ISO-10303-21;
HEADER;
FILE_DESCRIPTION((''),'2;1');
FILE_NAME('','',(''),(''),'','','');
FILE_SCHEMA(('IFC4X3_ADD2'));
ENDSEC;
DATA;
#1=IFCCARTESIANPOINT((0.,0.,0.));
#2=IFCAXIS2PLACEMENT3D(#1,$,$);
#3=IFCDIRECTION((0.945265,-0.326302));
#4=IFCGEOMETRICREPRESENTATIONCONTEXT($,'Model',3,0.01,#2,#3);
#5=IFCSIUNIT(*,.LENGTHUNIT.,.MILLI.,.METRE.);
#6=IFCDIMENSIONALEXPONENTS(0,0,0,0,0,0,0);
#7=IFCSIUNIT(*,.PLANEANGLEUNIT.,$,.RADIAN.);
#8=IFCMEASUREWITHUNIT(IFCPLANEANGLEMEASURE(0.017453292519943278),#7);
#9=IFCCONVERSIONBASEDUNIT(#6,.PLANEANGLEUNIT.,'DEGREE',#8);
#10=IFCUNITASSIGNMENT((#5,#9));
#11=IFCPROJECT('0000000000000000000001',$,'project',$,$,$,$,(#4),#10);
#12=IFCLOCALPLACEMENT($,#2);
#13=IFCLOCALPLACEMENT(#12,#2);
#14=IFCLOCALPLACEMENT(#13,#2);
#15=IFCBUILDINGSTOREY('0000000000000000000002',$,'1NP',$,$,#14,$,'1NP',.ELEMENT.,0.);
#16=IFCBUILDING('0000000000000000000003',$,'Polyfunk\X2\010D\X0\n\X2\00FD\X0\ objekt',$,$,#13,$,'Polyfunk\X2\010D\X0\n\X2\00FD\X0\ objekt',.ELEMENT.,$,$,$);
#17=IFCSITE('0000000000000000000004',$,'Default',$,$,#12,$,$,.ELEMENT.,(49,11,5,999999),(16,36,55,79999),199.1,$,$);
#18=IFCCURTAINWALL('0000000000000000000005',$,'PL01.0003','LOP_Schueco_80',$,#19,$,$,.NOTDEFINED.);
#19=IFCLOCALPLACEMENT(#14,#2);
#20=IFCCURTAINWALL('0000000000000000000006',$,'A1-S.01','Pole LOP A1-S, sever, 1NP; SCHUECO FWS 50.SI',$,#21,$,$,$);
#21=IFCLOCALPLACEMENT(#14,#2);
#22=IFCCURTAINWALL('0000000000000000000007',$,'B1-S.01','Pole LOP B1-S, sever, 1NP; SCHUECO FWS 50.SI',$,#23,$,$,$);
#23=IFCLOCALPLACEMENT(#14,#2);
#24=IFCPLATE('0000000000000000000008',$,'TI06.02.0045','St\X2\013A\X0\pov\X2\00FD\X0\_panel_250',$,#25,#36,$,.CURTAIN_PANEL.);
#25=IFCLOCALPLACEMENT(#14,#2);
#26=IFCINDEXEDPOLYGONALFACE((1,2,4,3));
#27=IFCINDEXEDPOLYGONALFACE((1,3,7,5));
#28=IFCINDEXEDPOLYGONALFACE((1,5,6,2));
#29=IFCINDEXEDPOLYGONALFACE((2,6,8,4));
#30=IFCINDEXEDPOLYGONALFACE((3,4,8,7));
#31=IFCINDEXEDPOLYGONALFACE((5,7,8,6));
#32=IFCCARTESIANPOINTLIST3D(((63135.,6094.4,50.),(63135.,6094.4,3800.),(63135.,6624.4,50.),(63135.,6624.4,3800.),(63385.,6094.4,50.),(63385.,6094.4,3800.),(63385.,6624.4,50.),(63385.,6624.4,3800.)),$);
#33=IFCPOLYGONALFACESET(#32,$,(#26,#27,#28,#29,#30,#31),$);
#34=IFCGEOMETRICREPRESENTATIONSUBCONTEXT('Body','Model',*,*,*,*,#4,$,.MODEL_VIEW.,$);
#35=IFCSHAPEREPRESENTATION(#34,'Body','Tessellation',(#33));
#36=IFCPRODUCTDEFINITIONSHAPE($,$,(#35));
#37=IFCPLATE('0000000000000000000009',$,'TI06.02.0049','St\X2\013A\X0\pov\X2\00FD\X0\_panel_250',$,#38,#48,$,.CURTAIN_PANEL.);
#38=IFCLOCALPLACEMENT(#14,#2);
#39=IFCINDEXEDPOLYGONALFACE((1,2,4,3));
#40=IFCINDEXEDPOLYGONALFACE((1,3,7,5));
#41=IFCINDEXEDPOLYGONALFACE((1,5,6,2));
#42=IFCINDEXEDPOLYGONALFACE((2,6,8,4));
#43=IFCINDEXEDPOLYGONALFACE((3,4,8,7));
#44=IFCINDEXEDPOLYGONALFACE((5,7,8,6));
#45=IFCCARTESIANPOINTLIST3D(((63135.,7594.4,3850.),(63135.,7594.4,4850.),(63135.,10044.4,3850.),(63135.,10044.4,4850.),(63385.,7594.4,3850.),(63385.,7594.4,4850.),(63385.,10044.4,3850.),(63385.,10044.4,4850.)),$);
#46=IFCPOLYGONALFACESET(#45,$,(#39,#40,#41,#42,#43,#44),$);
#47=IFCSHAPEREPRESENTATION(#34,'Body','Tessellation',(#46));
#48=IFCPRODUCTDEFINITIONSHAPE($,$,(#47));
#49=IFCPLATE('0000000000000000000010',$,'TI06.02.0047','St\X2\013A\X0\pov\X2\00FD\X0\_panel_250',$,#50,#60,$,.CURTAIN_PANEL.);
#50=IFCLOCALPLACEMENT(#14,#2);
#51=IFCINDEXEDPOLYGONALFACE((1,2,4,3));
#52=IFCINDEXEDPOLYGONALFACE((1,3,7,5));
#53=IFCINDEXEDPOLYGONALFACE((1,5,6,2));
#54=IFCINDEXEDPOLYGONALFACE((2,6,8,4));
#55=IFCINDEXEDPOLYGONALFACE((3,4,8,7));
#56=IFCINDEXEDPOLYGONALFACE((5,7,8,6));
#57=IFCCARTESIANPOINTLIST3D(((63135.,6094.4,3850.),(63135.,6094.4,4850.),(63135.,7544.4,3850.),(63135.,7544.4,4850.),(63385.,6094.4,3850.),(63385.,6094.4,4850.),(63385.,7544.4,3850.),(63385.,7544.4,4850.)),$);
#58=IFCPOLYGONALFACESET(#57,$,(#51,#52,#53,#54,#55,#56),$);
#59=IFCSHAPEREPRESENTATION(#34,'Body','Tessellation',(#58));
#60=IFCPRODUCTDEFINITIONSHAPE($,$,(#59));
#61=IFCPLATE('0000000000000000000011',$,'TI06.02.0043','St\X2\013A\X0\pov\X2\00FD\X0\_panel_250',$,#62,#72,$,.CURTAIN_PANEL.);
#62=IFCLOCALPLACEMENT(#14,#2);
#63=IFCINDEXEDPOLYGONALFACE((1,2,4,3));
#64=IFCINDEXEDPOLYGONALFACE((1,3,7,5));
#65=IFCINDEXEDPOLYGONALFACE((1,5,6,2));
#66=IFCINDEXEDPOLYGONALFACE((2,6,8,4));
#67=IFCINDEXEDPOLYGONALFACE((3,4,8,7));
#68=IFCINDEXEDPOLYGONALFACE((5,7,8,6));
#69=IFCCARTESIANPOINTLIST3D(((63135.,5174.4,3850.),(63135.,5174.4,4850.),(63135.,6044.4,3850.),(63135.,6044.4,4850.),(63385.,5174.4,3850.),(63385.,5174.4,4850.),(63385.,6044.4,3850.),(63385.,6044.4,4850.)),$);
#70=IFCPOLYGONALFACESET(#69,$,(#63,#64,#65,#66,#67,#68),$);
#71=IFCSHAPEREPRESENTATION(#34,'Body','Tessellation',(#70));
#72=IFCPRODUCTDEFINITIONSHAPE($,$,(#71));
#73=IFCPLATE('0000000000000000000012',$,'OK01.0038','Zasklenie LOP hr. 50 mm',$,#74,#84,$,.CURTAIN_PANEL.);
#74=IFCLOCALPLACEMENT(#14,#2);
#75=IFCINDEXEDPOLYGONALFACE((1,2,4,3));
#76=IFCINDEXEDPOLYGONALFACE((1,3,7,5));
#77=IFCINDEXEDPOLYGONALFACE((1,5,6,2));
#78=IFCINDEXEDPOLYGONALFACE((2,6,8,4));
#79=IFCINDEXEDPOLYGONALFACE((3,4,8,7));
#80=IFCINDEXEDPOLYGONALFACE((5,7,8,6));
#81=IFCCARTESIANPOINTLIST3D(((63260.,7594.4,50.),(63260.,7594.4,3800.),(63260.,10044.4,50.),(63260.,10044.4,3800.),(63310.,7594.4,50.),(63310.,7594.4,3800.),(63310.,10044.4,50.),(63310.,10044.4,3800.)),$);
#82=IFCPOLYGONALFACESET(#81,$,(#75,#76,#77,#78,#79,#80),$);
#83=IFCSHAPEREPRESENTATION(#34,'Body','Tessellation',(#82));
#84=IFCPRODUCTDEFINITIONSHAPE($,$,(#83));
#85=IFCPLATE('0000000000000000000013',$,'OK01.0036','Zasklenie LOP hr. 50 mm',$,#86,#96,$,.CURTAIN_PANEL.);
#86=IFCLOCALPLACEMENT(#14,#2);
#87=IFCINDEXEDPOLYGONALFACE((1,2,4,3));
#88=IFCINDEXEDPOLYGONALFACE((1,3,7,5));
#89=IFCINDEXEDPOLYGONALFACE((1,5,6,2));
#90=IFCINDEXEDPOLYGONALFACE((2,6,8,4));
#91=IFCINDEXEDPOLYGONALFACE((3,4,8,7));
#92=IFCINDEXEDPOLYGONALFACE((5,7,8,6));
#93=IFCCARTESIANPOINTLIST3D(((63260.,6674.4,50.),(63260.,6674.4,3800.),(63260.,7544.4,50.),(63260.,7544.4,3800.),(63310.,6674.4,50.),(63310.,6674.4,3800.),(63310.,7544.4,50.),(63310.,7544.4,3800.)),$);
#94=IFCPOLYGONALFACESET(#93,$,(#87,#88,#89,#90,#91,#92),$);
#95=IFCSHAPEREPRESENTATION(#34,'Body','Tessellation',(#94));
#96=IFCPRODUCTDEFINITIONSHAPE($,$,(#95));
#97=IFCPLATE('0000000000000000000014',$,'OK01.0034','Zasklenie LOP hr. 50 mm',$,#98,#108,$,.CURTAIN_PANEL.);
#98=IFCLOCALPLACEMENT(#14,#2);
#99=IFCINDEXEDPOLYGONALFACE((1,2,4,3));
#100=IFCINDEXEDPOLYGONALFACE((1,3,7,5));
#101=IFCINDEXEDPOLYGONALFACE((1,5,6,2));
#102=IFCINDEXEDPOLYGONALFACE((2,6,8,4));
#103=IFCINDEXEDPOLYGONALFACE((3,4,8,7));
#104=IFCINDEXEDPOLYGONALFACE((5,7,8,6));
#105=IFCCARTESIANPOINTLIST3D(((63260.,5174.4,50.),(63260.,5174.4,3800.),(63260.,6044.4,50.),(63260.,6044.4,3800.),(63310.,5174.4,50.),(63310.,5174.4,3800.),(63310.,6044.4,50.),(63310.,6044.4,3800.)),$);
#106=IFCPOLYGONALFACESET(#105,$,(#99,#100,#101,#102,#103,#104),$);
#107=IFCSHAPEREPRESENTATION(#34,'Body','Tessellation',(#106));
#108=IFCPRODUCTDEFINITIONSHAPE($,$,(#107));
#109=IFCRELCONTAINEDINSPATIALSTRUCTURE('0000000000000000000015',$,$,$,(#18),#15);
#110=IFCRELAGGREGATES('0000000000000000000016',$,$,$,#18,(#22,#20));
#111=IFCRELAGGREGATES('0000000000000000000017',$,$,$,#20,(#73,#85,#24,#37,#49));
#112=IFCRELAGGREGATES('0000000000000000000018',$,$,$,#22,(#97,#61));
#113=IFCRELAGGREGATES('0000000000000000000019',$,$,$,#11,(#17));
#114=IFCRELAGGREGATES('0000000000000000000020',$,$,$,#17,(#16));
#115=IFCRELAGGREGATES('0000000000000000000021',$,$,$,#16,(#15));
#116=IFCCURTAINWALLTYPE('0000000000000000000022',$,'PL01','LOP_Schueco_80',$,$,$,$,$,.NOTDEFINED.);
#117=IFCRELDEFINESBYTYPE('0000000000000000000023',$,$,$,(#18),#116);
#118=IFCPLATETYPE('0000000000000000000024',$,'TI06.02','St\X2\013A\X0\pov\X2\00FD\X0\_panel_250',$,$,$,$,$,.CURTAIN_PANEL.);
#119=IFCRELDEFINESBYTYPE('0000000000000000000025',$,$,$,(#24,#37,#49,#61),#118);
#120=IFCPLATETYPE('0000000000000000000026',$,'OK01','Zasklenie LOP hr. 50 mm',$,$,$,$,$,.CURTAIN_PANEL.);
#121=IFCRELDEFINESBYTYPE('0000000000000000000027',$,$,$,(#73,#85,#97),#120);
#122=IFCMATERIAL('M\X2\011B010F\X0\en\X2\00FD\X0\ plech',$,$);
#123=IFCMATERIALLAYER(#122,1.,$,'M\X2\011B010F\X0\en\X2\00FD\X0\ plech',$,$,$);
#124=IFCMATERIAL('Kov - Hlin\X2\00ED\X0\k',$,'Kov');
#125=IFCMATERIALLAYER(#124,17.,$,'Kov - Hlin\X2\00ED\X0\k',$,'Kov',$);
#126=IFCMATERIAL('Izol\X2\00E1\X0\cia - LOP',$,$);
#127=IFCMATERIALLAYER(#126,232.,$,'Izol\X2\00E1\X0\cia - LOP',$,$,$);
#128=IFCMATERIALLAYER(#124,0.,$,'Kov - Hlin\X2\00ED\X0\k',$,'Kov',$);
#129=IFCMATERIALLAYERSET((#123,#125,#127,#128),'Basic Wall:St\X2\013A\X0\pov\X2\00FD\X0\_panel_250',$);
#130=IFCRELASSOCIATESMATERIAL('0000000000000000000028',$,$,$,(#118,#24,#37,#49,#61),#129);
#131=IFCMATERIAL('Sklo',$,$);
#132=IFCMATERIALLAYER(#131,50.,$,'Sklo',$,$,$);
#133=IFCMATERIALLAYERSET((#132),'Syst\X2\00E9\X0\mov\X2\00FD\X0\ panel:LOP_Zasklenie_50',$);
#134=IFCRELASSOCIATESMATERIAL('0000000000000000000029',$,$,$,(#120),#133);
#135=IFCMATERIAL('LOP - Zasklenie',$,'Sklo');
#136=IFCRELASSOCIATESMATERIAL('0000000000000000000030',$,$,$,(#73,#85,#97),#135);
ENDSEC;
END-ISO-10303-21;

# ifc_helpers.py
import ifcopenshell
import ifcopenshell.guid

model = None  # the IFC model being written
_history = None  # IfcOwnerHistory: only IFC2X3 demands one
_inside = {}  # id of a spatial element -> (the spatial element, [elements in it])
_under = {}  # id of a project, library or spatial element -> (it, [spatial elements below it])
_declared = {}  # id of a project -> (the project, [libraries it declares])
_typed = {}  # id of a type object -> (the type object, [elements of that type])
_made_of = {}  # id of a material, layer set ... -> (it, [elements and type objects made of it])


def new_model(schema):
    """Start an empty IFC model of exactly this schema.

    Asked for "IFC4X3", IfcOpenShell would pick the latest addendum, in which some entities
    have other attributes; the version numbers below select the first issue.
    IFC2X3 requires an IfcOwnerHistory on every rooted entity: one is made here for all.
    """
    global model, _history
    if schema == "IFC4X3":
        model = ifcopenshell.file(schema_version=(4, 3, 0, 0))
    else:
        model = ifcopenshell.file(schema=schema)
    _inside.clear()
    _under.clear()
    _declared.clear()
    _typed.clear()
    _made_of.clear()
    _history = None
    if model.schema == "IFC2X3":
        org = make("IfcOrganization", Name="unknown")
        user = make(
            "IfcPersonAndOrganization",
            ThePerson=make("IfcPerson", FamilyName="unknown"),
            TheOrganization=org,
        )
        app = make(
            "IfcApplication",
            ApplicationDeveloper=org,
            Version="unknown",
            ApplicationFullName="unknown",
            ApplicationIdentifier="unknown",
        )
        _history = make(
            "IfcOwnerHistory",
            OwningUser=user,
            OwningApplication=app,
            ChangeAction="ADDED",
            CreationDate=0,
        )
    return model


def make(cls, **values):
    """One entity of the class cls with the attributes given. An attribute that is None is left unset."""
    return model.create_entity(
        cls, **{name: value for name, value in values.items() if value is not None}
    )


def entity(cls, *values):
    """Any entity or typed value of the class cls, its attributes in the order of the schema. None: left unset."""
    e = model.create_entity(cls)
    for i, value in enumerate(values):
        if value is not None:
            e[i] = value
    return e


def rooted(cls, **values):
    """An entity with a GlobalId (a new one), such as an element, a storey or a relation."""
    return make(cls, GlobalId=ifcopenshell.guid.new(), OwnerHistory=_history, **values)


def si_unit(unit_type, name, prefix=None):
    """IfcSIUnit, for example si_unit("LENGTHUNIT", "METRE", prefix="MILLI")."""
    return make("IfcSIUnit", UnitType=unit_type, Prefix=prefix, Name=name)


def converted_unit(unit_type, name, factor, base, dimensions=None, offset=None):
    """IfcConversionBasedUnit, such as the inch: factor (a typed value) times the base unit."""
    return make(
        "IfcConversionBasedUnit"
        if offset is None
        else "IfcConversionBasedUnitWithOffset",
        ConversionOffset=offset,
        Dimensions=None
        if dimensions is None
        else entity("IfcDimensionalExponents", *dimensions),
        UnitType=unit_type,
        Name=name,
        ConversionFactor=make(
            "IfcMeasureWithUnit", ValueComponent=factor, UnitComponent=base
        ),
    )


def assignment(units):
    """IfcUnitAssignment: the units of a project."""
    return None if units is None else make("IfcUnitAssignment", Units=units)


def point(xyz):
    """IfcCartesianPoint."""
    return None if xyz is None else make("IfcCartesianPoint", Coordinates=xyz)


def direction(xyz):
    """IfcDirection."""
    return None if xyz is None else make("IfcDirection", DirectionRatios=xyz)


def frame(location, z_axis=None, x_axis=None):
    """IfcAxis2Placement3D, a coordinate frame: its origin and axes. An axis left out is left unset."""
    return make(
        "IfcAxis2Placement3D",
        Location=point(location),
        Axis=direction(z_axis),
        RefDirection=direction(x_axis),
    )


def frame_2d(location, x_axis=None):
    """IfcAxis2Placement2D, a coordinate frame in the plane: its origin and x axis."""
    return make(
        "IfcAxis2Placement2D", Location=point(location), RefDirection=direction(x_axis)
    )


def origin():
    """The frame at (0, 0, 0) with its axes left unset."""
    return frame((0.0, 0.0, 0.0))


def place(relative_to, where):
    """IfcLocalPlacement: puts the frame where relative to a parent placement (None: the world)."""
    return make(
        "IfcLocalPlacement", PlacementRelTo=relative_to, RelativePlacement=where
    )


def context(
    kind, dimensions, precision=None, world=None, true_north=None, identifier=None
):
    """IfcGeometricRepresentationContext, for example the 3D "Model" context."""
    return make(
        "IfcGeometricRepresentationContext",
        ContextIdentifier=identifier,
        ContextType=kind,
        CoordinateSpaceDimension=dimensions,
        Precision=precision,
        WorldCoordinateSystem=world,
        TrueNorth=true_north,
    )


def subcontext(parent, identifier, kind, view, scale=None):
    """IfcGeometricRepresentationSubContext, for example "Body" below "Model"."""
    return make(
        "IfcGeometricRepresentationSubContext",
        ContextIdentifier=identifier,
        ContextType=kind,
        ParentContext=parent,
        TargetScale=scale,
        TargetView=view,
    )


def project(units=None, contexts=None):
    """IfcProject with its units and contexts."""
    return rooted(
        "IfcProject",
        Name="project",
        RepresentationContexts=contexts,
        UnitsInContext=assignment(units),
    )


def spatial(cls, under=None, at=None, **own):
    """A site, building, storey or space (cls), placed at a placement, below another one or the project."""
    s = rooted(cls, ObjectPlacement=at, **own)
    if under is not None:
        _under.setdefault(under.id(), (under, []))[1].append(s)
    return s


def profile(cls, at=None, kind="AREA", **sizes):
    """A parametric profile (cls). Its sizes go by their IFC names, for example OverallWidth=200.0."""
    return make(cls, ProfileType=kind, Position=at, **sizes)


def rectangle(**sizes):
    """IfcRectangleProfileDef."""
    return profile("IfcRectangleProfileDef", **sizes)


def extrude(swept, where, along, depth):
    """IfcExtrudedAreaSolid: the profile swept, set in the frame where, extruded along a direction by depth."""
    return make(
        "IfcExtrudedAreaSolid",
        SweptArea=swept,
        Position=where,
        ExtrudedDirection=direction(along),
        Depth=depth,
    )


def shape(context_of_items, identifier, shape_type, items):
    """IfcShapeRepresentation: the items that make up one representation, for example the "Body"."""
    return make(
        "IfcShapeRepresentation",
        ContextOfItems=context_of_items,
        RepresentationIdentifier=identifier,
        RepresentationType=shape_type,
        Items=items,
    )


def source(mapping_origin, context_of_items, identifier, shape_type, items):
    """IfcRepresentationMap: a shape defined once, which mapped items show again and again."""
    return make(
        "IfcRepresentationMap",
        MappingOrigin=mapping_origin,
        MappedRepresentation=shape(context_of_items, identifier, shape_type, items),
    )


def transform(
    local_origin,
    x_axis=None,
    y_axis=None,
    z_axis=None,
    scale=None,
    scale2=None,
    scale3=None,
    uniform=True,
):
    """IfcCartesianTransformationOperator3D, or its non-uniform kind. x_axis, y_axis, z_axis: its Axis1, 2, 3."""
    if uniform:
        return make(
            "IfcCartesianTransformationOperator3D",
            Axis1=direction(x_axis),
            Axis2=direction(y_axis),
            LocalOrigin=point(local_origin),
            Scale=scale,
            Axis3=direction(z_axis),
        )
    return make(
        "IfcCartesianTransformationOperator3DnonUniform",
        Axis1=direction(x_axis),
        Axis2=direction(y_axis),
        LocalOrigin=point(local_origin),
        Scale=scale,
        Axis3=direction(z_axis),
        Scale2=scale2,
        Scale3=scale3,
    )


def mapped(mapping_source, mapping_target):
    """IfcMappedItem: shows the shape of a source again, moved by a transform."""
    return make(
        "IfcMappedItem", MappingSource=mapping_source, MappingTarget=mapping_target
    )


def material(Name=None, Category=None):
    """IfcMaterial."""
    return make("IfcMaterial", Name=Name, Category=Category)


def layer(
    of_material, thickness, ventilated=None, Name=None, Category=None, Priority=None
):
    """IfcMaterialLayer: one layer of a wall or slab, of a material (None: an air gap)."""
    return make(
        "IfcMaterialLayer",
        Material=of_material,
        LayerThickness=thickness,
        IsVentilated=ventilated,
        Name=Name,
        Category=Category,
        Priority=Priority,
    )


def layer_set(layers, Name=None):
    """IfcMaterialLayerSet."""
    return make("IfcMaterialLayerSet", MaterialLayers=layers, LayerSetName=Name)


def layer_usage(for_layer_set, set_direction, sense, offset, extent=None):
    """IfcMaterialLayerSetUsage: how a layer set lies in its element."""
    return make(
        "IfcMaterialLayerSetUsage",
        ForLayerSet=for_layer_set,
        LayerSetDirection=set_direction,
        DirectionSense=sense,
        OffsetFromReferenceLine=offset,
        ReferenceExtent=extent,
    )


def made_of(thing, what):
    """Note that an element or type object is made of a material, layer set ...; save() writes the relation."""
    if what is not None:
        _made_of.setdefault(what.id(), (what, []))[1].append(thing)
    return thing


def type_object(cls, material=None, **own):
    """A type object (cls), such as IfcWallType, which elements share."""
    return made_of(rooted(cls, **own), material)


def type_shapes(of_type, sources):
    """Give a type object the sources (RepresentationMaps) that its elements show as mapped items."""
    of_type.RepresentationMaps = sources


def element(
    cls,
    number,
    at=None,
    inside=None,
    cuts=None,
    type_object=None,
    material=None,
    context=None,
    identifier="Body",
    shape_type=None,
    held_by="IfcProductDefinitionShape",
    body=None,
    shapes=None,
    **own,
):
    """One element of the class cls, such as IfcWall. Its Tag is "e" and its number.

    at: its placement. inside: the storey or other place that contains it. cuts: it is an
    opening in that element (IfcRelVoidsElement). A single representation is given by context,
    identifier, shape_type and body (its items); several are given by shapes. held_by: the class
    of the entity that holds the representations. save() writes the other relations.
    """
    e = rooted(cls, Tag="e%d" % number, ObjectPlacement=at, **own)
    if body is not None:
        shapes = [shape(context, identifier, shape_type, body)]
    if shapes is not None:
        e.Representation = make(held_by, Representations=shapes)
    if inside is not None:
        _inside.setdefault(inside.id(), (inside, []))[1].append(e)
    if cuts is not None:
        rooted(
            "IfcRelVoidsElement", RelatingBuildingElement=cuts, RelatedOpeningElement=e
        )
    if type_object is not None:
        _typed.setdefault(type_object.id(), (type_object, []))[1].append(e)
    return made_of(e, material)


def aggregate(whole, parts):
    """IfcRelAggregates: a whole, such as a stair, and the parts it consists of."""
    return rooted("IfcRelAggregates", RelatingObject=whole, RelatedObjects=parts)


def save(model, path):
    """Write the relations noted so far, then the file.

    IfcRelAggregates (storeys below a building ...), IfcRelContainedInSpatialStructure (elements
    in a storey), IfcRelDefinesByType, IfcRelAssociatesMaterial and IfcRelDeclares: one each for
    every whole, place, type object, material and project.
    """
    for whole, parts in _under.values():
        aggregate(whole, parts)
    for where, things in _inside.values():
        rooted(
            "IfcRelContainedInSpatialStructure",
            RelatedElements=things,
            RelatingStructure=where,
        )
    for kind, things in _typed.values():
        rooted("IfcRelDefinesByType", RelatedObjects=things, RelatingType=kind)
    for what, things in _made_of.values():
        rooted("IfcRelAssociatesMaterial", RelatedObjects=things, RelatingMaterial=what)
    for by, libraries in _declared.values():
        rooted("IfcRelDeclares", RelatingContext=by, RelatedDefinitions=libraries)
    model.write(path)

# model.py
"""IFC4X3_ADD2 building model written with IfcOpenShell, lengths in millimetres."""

from ifc_helpers import new_model, entity, si_unit, converted_unit, direction, frame, frame_2d, origin, place, context, subcontext, project, spatial, rectangle, extrude, source, transform, mapped, material, layer, layer_set, layer_usage, type_object, type_shapes, element, aggregate, save


model = new_model("IFC4X3_ADD2")

# Units and contexts
model_context = context("Model", 3, precision=0.01, world=origin(), true_north=direction((0.945265, -0.326302)))
body_context = subcontext(model_context, "Body", "Model", "MODEL_VIEW")
ifc_project = project(units=[si_unit("LENGTHUNIT", "METRE", prefix="MILLI"), converted_unit("PLANEANGLEUNIT", "DEGREE", entity("IfcPlaneAngleMeasure", 0.017453292519943278), si_unit("PLANEANGLEUNIT", "RADIAN"), dimensions=[0, 0, 0, 0, 0, 0, 0])], contexts=[model_context])

# Site, building, storey
site_placement = place(None, origin())
site = spatial("IfcSite", under=ifc_project, at=site_placement, Name="Default", CompositionType="ELEMENT", RefLatitude=(49, 11, 5, 999999), RefLongitude=(16, 36, 55, 79999), RefElevation=199.1)
building_placement = place(site_placement, origin())
building = spatial("IfcBuilding", under=site, at=building_placement, Name="Polyfunkčný objekt", LongName="Polyfunkčný objekt", CompositionType="ELEMENT")
storey_placement = place(building_placement, origin())
storey = spatial("IfcBuildingStorey", under=building, at=storey_placement, Name="1NP", LongName="1NP", CompositionType="ELEMENT", Elevation=0.0)

# Curtain walls, plates
curtain_wall_type = type_object("IfcCurtainWallType", Name="PL01", Description="LOP_Schueco_80", PredefinedType="NOTDEFINED")
curtain_wall_1_placement = place(storey_placement, origin())
curtain_wall_1 = element("IfcCurtainWall", 1, at=curtain_wall_1_placement, inside=storey, type_object=curtain_wall_type, Name="PL01.0003", Description="LOP_Schueco_80", PredefinedType="NOTDEFINED")
curtain_wall_2 = element("IfcCurtainWall", 2, Name="A1-S.01", Description="Pole LOP A1-S, sever, 1NP; SCHUECO FWS 50.SI")
curtain_wall_3 = element("IfcCurtainWall", 3, Name="B1-S.01", Description="Pole LOP B1-S, sever, 1NP; SCHUECO FWS 50.SI")
aggregate(curtain_wall_1, [curtain_wall_3, curtain_wall_2])
ifc_material_1 = material(Name="Měďený plech")
ifc_layer_1 = layer(ifc_material_1, 1.0, Name="Měďený plech")
ifc_material_2 = material(Name="Kov - Hliník", Category="Kov")
ifc_layer_2 = layer(ifc_material_2, 17.0, Name="Kov - Hliník", Category="Kov")
ifc_material_3 = material(Name="Izolácia - LOP")
ifc_layer_3 = layer(ifc_material_3, 232.0, Name="Izolácia - LOP")
ifc_layer_4 = layer(ifc_material_2, 0.0, Name="Kov - Hliník", Category="Kov")
ifc_layer_set_1 = layer_set([ifc_layer_1, ifc_layer_2, ifc_layer_3, ifc_layer_4], Name="Basic Wall:Stĺpový_panel_250")
ifc_layer_usage_1 = layer_usage(ifc_layer_set_1, "AXIS2", "NEGATIVE", 125.0)
plate_type_1 = type_object("IfcPlateType", Name="TI06.02", Description="Stĺpový_panel_250", PredefinedType="CURTAIN_PANEL", material=ifc_layer_set_1)
plate_1_placement = place(storey_placement, frame((63260.0, 6624.4, 50.0), z_axis=(0.0, 0.0, 1.0), x_axis=(0.0, -1.0, 0.0)))
plate_1 = element("IfcPlate", 4, at=plate_1_placement, type_object=plate_type_1, material=ifc_layer_usage_1, Name="TI06.02.0045", Description="Stĺpový_panel_250", PredefinedType="CURTAIN_PANEL", context=body_context, shape_type="SweptSolid", body=[
    extrude(rectangle(XDim=250.0, YDim=530.0, at=frame_2d((0.0, 0.0), x_axis=(1.0, 0.0))), frame((265.0, 0.0, 0.0), z_axis=(0.0, 0.0, 1.0), x_axis=(0.0, 1.0, 0.0)), (0.0, 0.0, 1.0), 3750.0),
])
ifc_layer_usage_2 = layer_usage(ifc_layer_set_1, "AXIS2", "NEGATIVE", 125.0)
plate_2_placement = place(storey_placement, frame((63260.0, 10044.4, 3850.0), z_axis=(0.0, 0.0, 1.0), x_axis=(0.0, -1.0, 0.0)))
plate_2 = element("IfcPlate", 5, at=plate_2_placement, type_object=plate_type_1, material=ifc_layer_usage_2, Name="TI06.02.0049", Description="Stĺpový_panel_250", PredefinedType="CURTAIN_PANEL", context=body_context, shape_type="SweptSolid", body=[
    extrude(rectangle(XDim=250.0, YDim=2450.0, at=frame_2d((0.0, 0.0), x_axis=(1.0, 0.0))), frame((1225.0, 0.0, 0.0), z_axis=(0.0, 0.0, 1.0), x_axis=(0.0, 1.0, 0.0)), (0.0, 0.0, 1.0), 1000.0),
])
ifc_layer_usage_3 = layer_usage(ifc_layer_set_1, "AXIS2", "NEGATIVE", 125.0)
plate_3_placement = place(storey_placement, frame((63260.0, 7544.4, 3850.0), z_axis=(0.0, 0.0, 1.0), x_axis=(0.0, -1.0, 0.0)))
plate_3 = element("IfcPlate", 6, at=plate_3_placement, type_object=plate_type_1, material=ifc_layer_usage_3, Name="TI06.02.0047", Description="Stĺpový_panel_250", PredefinedType="CURTAIN_PANEL", context=body_context, shape_type="SweptSolid", body=[
    extrude(rectangle(XDim=250.0, YDim=1450.0, at=frame_2d((0.0, 0.0), x_axis=(1.0, 0.0))), frame((725.0, 0.0, 0.0), z_axis=(0.0, 0.0, 1.0), x_axis=(0.0, 1.0, 0.0)), (0.0, 0.0, 1.0), 1000.0),
])
ifc_layer_usage_4 = layer_usage(ifc_layer_set_1, "AXIS2", "NEGATIVE", 125.0)
plate_4_placement = place(storey_placement, frame((63260.0, 6044.4, 3850.0), z_axis=(0.0, 0.0, 1.0), x_axis=(0.0, -1.0, 0.0)))
plate_4 = element("IfcPlate", 7, at=plate_4_placement, type_object=plate_type_1, material=ifc_layer_usage_4, Name="TI06.02.0043", Description="Stĺpový_panel_250", PredefinedType="CURTAIN_PANEL", context=body_context, shape_type="SweptSolid", body=[
    extrude(rectangle(XDim=250.0, YDim=870.0, at=frame_2d((0.0, 0.0), x_axis=(1.0, 0.0))), frame((435.0, 0.0, 0.0), z_axis=(0.0, 0.0, 1.0), x_axis=(0.0, 1.0, 0.0)), (0.0, 0.0, 1.0), 1000.0),
])
ifc_material_4 = material(Name="LOP - Zasklenie", Category="Sklo")
ifc_material_5 = material(Name="Sklo")
ifc_layer_5 = layer(ifc_material_5, 50.0, Name="Sklo")
ifc_layer_set_2 = layer_set([ifc_layer_5], Name="Systémový panel:LOP_Zasklenie_50")
plate_type_2 = type_object("IfcPlateType", Name="OK01", Description="Zasklenie LOP hr. 50 mm", PredefinedType="CURTAIN_PANEL", material=ifc_layer_set_2)
shared_shape_1 = source(origin(), body_context, "Body", "SweptSolid", [
    extrude(rectangle(XDim=3750.0, YDim=2450.0, at=frame_2d((-141.7, 0.0), x_axis=(1.0, 0.0))), frame((0.0, 0.0, 2016.7), z_axis=(0.0, 1.0, 0.0), x_axis=(0.0, 0.0, 1.0)), (0.0, 0.0, 1.0), 50.0),
])
plate_5_placement = place(curtain_wall_1_placement, frame((63260.0, 8819.4, 50.0), z_axis=(0.0, 0.0, 1.0), x_axis=(0.0, -1.0, 0.0)))
plate_5 = element("IfcPlate", 8, at=plate_5_placement, type_object=plate_type_2, material=ifc_material_4, Name="OK01.0038", Description="Zasklenie LOP hr. 50 mm", PredefinedType="CURTAIN_PANEL", context=body_context, shape_type="MappedRepresentation", body=[
    mapped(shared_shape_1, transform((0.0, 0.0, 0.0), scale=1.0)),
])
shared_shape_2 = source(origin(), body_context, "Body", "SweptSolid", [
    extrude(rectangle(XDim=3750.0, YDim=870.0, at=frame_2d((-141.7, 0.0), x_axis=(1.0, 0.0))), frame((0.0, 0.0, 2016.7), z_axis=(0.0, 1.0, 0.0), x_axis=(0.0, 0.0, 1.0)), (0.0, 0.0, 1.0), 50.0),
])
type_shapes(plate_type_2, [shared_shape_1, shared_shape_2])
plate_6_placement = place(curtain_wall_1_placement, frame((63260.0, 7109.4, 50.0), z_axis=(0.0, 0.0, 1.0), x_axis=(0.0, -1.0, 0.0)))
plate_6 = element("IfcPlate", 9, at=plate_6_placement, type_object=plate_type_2, material=ifc_material_4, Name="OK01.0036", Description="Zasklenie LOP hr. 50 mm", PredefinedType="CURTAIN_PANEL", context=body_context, shape_type="MappedRepresentation", body=[
    mapped(shared_shape_2, transform((0.0, 0.0, 0.0), scale=1.0)),
])
aggregate(curtain_wall_2, [plate_5, plate_6, plate_1, plate_2, plate_3])
plate_7_placement = place(curtain_wall_1_placement, frame((63260.0, 5609.4, 50.0), z_axis=(0.0, 0.0, 1.0), x_axis=(0.0, -1.0, 0.0)))
plate_7 = element("IfcPlate", 10, at=plate_7_placement, type_object=plate_type_2, material=ifc_material_4, Name="OK01.0034", Description="Zasklenie LOP hr. 50 mm", PredefinedType="CURTAIN_PANEL", context=body_context, shape_type="MappedRepresentation", body=[
    mapped(shared_shape_2, transform((0.0, 0.0, 0.0), scale=1.0)),
])
aggregate(curtain_wall_3, [plate_7, plate_4])

save(model, "model.ifc")
